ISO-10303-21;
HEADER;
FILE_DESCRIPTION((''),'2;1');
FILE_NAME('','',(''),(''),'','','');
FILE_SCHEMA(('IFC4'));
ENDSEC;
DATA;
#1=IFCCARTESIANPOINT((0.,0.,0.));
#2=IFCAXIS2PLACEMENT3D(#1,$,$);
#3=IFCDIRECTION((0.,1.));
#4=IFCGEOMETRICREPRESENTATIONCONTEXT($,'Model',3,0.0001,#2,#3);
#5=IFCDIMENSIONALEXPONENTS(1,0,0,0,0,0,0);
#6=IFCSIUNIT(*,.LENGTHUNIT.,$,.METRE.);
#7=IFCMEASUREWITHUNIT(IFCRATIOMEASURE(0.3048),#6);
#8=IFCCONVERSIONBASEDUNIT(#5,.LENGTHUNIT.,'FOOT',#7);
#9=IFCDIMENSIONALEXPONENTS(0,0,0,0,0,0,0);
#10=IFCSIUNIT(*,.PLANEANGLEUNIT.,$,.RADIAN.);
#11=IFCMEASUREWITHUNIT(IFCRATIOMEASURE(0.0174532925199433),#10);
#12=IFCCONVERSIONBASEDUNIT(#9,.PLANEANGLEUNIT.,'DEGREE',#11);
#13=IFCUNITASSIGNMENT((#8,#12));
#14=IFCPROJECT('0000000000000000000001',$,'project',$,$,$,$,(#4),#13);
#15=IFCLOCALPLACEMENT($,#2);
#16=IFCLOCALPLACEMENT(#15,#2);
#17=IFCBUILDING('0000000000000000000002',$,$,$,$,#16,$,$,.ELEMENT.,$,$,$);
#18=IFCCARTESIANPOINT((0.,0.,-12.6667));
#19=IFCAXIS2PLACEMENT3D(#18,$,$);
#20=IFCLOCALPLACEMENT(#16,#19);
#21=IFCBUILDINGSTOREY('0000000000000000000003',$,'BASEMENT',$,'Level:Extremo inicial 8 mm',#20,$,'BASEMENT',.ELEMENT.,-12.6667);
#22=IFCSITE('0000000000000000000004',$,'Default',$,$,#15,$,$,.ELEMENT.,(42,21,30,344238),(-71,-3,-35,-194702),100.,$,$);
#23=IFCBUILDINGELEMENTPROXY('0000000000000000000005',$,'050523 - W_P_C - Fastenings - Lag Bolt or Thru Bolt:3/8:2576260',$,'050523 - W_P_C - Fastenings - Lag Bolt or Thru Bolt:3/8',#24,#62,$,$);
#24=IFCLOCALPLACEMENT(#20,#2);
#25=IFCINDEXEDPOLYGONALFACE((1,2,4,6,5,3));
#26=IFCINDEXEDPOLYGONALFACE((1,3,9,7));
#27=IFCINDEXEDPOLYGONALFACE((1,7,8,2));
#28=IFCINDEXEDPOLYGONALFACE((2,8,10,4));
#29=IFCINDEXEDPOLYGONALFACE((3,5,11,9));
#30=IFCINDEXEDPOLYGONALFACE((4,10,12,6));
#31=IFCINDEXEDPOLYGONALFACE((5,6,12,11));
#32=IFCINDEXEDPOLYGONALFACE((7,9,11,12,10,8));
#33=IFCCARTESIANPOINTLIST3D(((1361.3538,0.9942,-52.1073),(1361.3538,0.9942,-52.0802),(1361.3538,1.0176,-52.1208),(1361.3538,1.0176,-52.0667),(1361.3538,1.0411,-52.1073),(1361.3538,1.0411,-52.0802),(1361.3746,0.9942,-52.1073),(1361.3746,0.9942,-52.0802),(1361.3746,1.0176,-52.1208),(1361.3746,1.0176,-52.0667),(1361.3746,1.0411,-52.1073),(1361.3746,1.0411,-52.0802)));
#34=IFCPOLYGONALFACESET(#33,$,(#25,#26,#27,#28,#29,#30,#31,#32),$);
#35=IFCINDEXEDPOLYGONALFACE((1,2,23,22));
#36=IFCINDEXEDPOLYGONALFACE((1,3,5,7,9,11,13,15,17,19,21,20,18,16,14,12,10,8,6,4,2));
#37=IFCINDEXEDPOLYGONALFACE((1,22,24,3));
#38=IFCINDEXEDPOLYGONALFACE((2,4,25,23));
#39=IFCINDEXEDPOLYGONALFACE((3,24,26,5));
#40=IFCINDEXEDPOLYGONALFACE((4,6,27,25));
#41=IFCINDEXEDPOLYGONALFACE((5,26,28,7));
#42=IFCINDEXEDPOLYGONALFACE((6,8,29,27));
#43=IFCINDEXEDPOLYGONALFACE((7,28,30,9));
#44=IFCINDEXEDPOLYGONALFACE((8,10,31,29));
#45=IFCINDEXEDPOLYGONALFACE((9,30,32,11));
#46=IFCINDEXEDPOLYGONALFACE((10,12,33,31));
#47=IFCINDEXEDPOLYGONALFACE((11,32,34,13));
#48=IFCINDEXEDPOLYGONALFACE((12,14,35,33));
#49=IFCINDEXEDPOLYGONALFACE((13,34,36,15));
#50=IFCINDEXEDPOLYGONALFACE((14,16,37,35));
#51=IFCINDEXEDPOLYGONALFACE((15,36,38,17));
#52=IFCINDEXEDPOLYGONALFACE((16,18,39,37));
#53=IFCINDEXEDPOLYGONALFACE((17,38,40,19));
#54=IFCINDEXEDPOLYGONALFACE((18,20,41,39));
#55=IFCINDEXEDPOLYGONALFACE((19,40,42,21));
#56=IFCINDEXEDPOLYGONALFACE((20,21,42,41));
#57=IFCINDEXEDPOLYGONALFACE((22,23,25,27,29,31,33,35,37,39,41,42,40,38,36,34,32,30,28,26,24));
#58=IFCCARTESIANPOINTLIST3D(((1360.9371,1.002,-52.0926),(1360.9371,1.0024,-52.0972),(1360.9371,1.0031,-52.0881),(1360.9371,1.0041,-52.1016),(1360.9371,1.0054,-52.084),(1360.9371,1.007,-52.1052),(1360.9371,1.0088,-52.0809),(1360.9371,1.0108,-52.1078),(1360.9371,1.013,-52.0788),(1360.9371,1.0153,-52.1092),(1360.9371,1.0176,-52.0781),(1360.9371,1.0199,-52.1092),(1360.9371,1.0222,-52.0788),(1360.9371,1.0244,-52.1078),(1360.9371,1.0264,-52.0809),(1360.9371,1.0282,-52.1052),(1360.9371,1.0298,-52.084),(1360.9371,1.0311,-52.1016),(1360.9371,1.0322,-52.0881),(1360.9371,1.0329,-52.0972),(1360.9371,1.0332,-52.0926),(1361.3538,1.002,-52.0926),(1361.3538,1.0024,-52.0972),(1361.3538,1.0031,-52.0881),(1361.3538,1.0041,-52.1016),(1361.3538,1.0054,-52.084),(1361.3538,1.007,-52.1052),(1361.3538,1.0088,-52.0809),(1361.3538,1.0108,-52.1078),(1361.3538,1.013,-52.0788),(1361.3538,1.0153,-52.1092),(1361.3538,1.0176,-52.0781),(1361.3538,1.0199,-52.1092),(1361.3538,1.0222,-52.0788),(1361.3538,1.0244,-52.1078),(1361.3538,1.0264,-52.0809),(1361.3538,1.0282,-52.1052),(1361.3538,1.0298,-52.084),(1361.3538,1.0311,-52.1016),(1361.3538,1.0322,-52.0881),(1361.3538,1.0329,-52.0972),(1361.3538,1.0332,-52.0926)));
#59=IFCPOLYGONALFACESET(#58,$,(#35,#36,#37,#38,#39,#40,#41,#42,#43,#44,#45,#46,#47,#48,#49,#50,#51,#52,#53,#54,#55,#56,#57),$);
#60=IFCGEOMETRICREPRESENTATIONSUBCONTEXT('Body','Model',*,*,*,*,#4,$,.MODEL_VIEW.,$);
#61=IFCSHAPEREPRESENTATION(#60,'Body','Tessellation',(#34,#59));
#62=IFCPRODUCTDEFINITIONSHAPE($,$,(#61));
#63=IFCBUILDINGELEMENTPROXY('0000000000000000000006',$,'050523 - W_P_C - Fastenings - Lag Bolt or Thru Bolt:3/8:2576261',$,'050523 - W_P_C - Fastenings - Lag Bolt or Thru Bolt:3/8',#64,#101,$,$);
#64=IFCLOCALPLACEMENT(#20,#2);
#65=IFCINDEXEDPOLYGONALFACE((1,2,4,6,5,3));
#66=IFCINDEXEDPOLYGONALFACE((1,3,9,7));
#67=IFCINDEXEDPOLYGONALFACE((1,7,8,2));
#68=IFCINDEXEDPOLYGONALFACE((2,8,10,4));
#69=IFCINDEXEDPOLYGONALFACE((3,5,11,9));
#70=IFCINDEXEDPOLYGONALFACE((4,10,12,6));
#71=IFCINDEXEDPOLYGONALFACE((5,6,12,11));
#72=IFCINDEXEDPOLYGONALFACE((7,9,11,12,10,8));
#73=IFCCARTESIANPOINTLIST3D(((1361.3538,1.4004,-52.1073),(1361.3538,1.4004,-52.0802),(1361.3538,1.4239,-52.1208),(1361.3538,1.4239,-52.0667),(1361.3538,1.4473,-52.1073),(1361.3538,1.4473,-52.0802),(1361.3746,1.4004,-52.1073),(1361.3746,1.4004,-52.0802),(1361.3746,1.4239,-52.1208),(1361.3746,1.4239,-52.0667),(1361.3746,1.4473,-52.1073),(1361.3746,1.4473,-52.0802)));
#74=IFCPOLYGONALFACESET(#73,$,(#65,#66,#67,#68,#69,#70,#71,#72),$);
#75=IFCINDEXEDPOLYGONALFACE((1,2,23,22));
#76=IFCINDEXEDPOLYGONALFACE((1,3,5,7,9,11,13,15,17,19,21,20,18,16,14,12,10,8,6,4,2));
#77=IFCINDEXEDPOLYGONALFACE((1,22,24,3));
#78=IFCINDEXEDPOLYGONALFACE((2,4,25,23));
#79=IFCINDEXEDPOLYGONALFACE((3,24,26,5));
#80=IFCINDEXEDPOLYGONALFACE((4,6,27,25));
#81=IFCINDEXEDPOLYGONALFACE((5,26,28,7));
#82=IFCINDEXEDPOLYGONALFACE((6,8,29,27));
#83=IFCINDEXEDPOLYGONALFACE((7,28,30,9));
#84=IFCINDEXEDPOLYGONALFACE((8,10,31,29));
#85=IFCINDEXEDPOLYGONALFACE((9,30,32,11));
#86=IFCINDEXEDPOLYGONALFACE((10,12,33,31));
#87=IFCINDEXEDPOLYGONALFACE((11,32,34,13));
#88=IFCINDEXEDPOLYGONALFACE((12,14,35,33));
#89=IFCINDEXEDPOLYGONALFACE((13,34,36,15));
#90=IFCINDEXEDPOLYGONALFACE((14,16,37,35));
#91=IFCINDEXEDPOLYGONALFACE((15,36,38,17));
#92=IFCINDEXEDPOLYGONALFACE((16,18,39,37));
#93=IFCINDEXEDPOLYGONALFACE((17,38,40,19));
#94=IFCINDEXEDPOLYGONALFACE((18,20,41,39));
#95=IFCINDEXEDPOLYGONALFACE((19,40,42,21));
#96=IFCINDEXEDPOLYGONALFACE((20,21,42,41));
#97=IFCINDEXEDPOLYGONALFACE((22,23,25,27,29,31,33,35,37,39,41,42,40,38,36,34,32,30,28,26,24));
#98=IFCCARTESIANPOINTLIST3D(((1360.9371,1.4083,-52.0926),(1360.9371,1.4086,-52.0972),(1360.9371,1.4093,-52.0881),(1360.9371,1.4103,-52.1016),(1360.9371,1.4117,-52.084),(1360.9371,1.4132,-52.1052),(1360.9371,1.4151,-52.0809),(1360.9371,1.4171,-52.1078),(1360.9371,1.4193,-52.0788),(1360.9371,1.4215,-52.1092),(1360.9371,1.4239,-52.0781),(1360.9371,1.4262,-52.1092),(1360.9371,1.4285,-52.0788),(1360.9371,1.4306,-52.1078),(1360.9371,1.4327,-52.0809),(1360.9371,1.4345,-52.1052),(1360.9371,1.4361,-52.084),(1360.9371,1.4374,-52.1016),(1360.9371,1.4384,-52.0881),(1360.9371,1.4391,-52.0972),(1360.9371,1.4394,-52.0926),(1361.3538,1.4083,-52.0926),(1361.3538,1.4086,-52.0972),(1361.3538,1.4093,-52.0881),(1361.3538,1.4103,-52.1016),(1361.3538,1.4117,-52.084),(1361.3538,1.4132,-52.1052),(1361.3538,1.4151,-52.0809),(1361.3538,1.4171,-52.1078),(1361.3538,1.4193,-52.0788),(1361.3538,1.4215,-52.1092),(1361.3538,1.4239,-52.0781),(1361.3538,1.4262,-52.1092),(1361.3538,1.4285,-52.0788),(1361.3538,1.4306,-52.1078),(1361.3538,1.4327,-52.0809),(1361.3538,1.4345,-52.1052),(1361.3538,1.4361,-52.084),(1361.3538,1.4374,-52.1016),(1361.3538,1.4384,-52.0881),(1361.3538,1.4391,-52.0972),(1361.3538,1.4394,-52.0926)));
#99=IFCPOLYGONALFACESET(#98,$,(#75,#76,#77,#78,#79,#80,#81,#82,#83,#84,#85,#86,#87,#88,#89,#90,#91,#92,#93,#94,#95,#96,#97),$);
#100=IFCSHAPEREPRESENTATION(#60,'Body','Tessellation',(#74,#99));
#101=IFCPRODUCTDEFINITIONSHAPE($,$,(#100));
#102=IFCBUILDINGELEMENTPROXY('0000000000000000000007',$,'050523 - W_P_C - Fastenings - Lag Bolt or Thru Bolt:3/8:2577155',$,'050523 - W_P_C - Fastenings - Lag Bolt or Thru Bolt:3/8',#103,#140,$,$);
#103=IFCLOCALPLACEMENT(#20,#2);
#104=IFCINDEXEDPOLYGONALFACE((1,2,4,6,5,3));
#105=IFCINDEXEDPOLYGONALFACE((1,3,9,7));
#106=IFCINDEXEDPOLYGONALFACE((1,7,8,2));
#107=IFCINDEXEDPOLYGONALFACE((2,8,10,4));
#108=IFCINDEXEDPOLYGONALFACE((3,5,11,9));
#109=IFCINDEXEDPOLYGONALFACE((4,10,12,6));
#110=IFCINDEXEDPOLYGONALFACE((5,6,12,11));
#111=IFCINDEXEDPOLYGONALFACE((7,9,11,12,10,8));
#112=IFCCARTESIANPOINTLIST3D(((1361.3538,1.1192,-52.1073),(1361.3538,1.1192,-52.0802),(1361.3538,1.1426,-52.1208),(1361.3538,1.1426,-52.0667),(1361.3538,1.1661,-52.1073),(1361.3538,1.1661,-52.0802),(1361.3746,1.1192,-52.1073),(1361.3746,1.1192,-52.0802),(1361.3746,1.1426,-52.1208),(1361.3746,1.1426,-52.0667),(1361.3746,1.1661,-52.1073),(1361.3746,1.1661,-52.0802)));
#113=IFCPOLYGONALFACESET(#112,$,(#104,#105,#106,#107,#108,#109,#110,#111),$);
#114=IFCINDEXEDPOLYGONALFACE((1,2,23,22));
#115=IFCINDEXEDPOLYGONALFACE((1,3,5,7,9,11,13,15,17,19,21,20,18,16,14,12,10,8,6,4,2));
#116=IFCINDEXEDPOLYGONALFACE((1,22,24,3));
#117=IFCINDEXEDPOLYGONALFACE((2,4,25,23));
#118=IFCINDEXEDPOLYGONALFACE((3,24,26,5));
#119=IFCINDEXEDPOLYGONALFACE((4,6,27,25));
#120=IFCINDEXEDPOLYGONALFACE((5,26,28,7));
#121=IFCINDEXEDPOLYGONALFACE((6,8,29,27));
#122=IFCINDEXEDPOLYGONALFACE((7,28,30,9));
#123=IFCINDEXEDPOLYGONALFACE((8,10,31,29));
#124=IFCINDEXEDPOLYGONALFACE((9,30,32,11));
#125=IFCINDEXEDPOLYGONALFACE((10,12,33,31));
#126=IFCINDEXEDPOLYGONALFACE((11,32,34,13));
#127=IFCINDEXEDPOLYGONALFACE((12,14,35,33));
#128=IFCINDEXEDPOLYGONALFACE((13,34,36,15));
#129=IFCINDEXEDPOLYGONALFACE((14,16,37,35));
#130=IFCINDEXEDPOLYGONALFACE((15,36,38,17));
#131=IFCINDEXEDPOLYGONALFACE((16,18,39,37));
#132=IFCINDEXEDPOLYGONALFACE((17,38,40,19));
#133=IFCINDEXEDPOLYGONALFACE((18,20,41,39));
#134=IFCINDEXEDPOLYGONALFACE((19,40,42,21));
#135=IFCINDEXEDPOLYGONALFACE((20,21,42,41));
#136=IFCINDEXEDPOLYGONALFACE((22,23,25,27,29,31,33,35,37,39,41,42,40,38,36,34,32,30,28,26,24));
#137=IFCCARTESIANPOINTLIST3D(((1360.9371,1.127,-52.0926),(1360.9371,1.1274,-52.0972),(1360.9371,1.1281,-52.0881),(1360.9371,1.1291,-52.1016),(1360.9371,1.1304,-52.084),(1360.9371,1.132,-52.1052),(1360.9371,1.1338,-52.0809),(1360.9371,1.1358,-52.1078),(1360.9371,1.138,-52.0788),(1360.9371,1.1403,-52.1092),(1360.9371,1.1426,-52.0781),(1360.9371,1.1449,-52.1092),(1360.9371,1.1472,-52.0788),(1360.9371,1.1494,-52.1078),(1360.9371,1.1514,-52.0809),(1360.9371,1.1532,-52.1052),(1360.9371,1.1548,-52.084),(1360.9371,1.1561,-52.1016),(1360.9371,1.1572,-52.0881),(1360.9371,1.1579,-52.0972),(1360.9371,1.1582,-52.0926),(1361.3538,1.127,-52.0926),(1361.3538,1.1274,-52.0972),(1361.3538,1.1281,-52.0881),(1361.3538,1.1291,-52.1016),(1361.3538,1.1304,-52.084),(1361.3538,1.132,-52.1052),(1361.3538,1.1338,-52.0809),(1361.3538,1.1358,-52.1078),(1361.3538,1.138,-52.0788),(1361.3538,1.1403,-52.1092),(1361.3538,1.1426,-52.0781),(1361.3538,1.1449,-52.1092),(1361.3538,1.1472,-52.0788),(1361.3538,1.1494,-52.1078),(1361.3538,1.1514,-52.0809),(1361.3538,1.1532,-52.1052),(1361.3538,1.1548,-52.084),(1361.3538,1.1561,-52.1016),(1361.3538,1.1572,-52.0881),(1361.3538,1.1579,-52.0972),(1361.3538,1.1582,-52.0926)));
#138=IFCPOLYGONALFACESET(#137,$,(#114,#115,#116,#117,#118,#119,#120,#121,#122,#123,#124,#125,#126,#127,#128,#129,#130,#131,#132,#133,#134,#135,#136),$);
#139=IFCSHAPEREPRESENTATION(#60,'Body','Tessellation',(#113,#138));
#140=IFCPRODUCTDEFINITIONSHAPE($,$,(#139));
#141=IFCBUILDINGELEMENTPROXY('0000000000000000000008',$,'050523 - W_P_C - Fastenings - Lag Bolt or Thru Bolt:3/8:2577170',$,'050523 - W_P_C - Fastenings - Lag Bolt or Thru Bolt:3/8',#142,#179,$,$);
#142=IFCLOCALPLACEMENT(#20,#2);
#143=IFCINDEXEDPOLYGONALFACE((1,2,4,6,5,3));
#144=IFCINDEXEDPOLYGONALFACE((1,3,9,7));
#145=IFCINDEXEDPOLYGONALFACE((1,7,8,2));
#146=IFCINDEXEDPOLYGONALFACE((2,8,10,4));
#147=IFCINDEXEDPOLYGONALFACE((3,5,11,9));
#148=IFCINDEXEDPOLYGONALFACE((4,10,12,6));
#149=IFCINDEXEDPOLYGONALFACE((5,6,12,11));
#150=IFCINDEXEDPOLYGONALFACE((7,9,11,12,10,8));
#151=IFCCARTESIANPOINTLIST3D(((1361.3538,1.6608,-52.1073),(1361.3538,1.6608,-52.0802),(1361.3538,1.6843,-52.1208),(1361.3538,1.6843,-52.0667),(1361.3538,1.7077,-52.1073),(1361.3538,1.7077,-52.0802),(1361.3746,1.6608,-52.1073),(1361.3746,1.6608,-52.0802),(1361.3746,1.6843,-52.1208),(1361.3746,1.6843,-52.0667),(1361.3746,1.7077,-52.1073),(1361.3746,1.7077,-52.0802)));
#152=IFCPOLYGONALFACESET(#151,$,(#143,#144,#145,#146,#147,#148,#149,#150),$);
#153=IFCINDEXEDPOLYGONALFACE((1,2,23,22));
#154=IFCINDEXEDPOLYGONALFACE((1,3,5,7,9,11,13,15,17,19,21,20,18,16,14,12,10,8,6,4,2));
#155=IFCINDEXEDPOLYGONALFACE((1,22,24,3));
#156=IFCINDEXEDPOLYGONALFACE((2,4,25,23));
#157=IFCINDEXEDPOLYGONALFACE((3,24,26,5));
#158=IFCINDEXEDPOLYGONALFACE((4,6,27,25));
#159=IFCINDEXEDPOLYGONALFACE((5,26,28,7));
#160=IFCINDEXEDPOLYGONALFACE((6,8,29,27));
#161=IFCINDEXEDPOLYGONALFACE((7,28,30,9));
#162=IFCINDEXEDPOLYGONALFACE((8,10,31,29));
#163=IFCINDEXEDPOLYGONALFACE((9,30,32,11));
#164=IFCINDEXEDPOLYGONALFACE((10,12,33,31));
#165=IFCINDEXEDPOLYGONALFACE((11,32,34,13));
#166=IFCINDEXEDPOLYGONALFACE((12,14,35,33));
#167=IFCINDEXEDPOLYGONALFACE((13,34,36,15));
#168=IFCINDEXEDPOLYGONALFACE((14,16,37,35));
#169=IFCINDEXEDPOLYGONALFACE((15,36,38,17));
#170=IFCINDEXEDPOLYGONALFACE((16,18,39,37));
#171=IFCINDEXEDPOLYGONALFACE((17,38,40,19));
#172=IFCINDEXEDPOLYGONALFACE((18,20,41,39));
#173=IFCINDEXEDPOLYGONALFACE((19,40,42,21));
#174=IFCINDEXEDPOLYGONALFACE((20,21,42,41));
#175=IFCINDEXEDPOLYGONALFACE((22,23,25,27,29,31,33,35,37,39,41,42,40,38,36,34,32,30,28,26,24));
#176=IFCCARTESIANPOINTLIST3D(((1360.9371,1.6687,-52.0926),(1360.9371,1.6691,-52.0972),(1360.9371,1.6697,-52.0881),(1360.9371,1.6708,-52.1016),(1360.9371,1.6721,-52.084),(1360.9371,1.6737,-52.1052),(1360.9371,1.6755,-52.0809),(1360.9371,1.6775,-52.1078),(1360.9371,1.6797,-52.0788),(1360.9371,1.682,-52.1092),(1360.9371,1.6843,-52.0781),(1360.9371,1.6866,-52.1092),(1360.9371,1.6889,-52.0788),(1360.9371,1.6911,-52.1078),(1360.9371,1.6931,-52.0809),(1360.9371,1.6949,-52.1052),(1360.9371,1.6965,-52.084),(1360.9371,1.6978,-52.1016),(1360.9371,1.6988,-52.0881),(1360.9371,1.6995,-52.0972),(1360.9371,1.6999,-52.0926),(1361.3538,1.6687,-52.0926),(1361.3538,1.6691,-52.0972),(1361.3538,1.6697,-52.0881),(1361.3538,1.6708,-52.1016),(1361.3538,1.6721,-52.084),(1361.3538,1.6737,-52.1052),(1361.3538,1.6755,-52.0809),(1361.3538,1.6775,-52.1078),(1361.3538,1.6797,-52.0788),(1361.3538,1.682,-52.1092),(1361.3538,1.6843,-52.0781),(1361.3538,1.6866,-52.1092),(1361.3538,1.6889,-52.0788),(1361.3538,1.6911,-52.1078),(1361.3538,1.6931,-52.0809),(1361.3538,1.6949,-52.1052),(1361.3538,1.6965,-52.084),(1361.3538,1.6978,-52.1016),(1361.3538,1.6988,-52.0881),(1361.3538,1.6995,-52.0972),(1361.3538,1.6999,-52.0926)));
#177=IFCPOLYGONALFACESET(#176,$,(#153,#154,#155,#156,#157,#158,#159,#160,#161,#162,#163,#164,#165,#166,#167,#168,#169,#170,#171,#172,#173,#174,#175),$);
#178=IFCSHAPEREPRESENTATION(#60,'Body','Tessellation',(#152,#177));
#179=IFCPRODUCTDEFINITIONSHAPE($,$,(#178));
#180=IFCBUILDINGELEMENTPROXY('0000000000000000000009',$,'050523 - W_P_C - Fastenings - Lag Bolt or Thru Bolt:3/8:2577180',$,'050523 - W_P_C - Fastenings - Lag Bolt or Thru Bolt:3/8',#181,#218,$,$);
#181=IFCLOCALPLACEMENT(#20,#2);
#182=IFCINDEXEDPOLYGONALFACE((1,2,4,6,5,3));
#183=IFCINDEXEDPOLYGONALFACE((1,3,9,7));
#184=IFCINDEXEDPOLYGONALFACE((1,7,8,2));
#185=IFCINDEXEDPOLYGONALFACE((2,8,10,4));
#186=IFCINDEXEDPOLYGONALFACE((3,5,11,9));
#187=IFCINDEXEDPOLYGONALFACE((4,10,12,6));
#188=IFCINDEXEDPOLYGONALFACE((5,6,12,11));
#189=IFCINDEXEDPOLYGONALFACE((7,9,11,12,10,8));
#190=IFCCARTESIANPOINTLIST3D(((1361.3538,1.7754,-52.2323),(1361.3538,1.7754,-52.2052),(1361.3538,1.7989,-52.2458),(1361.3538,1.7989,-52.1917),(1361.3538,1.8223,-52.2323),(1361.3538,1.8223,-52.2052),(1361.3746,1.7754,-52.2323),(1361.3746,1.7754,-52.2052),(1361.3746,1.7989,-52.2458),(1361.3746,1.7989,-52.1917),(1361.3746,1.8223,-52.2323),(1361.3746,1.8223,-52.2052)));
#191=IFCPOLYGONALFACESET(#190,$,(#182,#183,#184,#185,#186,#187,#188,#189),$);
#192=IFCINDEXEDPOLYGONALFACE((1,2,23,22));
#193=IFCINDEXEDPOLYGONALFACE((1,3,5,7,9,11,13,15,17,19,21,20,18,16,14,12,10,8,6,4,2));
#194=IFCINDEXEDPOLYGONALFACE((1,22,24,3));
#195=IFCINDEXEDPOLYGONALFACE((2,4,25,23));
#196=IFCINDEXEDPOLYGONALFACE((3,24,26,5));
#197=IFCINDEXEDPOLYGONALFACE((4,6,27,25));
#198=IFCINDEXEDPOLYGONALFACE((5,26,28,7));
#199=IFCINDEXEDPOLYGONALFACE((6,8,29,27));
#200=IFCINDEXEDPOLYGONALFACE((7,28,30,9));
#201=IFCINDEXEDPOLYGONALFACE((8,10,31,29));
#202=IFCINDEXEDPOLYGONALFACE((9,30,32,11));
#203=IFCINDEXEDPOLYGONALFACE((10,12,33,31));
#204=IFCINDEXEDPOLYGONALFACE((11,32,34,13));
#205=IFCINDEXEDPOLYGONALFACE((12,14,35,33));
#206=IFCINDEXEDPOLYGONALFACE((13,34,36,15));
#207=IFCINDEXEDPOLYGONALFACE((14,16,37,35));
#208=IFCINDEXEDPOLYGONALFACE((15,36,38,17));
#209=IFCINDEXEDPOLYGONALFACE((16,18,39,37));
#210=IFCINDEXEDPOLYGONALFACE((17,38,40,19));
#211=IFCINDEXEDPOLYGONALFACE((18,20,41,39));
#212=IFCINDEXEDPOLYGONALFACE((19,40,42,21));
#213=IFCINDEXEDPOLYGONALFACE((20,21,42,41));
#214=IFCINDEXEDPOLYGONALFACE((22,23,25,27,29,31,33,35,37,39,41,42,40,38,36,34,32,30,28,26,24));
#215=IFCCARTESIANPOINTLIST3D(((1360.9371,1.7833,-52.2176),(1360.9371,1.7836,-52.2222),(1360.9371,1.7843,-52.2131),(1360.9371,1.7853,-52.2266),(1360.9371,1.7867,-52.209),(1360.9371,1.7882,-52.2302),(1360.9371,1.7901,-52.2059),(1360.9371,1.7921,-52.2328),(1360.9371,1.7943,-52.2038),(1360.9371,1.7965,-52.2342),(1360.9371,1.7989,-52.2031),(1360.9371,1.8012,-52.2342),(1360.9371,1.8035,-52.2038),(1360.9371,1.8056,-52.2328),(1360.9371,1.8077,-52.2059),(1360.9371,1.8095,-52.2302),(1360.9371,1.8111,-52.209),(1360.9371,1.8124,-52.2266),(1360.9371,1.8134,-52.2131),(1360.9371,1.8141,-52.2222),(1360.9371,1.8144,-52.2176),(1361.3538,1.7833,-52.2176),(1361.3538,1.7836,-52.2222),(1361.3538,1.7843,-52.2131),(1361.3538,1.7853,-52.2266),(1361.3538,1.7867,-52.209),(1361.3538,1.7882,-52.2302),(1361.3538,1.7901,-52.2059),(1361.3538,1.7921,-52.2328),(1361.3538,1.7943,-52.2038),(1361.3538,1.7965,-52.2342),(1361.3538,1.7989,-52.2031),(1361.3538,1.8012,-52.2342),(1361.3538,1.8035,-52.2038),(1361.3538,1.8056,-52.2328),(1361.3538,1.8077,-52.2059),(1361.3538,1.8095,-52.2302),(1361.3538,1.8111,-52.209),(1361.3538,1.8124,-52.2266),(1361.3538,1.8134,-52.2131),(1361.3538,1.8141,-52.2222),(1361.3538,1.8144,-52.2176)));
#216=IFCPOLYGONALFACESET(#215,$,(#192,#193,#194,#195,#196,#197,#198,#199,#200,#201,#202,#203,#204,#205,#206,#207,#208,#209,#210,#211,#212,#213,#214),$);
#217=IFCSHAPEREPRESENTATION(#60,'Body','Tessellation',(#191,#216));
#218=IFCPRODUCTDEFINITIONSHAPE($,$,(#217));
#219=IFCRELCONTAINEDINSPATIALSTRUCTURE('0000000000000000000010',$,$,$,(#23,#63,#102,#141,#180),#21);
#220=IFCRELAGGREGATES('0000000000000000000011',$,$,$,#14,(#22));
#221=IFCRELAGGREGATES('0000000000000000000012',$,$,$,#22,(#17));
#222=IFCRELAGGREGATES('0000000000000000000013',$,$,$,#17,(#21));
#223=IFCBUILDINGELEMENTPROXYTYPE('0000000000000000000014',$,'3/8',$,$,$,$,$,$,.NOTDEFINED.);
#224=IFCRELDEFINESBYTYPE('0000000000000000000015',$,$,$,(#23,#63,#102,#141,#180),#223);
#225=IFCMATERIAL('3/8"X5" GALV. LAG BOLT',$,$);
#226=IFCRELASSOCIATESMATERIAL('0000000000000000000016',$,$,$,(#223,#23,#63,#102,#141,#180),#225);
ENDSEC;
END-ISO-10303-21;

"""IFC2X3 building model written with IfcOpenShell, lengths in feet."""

from ifc_helpers import new_model, entity, si_unit, converted_unit, direction, frame, frame_2d, origin, place, context, subcontext, project, spatial, polyline, circle, outline, extrude, source, transform, mapped, material, type_object, type_shapes, element, save


model = new_model("IFC2X3")

# Units and contexts
model_context = context("Model", 3, precision=0.0001, world=origin(), true_north=direction((0.0, 1.0)))
body_context = subcontext(model_context, "Body", "Model", "MODEL_VIEW")
ifc_project = project(units=[converted_unit("LENGTHUNIT", "FOOT", entity("IfcRatioMeasure", 0.3048), si_unit("LENGTHUNIT", "METRE"), dimensions=[1, 0, 0, 0, 0, 0, 0]), converted_unit("PLANEANGLEUNIT", "DEGREE", entity("IfcRatioMeasure", 0.0174532925199433), si_unit("PLANEANGLEUNIT", "RADIAN"), dimensions=[0, 0, 0, 0, 0, 0, 0])], contexts=[model_context])

# Site, building, storey
site_placement = place(None, origin())
site = spatial("IfcSite", under=ifc_project, at=site_placement, Name="Default", CompositionType="ELEMENT", RefLatitude=(42, 21, 30, 344238), RefLongitude=(-71, -3, -35, -194702), RefElevation=100.0)
building_placement = place(site_placement, origin())
building = spatial("IfcBuilding", under=site, at=building_placement, CompositionType="ELEMENT")
storey_placement = place(building_placement, frame((0.0, 0.0, -12.6667)))
storey = spatial("IfcBuildingStorey", under=building, at=storey_placement, Name="BASEMENT", ObjectType="Level:Extremo inicial 8 mm", LongName="BASEMENT", CompositionType="ELEMENT", Elevation=-12.6667)

# Building element proxies
ifc_material_1 = material(Name="3/8\"X5\" GALV. LAG BOLT")
building_element_proxy_type_1 = type_object("IfcBuildingElementProxyType", Name="3/8", PredefinedType="NOTDEFINED", material=ifc_material_1)
shared_shape_1 = source(origin(), body_context, "Body", "SweptSolid", [
    extrude(outline(polyline([(-0.0135, -0.0234), (0.0135, -0.0234), (0.0271, 0.0), (0.0135, 0.0234), (-0.0135, 0.0234), (-0.0271, 0.0), (-0.0135, -0.0234)])), frame((0.0, 0.0, 0.0), z_axis=(0.0, 0.0, 1.0), x_axis=(0.0, -1.0, 0.0)), (0.0, 0.0, 1.0), 0.0208),
    extrude(circle(Radius=0.0156, at=frame_2d((0.0, 0.0), x_axis=(1.0, 0.0))), frame((0.0, 0.0, -0.4167), z_axis=(0.0, 0.0, 1.0), x_axis=(0.0, 1.0, 0.0)), (0.0, 0.0, 1.0), 0.4167),
])
type_shapes(building_element_proxy_type_1, [shared_shape_1])
for number, where, z_axis, x_axis, name in (
    (1, (1361.3538, 1.0176, -52.0938), (1.0, 0.0, 0.0), (0.0, 1.0, 0.0), "050523 - W_P_C - Fastenings - Lag Bolt or Thru Bolt:3/8:2576260"),
    (2, (1361.3538, 1.4239, -52.0938), (1.0, 0.0, 0.0), (0.0, 1.0, 0.0), "050523 - W_P_C - Fastenings - Lag Bolt or Thru Bolt:3/8:2576261"),
    (3, (1361.3538, 1.1426, -52.0938), (1.0, 0.0, 0.0), (0.0, 1.0, 0.0), "050523 - W_P_C - Fastenings - Lag Bolt or Thru Bolt:3/8:2577155"),
    (4, (1361.3538, 1.6843, -52.0938), (1.0, 0.0, 0.0), (0.0, 1.0, 0.0), "050523 - W_P_C - Fastenings - Lag Bolt or Thru Bolt:3/8:2577170"),
    (5, (1361.3538, 1.7989, -52.2188), (1.0, 0.0, 0.0), (0.0, 1.0, 0.0), "050523 - W_P_C - Fastenings - Lag Bolt or Thru Bolt:3/8:2577180"),
):
    element("IfcBuildingElementProxy", number, at=place(storey_placement, frame(where, z_axis=z_axis, x_axis=x_axis)), inside=storey, type_object=building_element_proxy_type_1, material=ifc_material_1, Name=name, ObjectType="050523 - W_P_C - Fastenings - Lag Bolt or Thru Bolt:3/8", context=body_context, shape_type="MappedRepresentation", body=[
        mapped(shared_shape_1, transform((0.0, 0.0, 0.0), scale=1.0)),
    ])

save(model, "model.ifc")
